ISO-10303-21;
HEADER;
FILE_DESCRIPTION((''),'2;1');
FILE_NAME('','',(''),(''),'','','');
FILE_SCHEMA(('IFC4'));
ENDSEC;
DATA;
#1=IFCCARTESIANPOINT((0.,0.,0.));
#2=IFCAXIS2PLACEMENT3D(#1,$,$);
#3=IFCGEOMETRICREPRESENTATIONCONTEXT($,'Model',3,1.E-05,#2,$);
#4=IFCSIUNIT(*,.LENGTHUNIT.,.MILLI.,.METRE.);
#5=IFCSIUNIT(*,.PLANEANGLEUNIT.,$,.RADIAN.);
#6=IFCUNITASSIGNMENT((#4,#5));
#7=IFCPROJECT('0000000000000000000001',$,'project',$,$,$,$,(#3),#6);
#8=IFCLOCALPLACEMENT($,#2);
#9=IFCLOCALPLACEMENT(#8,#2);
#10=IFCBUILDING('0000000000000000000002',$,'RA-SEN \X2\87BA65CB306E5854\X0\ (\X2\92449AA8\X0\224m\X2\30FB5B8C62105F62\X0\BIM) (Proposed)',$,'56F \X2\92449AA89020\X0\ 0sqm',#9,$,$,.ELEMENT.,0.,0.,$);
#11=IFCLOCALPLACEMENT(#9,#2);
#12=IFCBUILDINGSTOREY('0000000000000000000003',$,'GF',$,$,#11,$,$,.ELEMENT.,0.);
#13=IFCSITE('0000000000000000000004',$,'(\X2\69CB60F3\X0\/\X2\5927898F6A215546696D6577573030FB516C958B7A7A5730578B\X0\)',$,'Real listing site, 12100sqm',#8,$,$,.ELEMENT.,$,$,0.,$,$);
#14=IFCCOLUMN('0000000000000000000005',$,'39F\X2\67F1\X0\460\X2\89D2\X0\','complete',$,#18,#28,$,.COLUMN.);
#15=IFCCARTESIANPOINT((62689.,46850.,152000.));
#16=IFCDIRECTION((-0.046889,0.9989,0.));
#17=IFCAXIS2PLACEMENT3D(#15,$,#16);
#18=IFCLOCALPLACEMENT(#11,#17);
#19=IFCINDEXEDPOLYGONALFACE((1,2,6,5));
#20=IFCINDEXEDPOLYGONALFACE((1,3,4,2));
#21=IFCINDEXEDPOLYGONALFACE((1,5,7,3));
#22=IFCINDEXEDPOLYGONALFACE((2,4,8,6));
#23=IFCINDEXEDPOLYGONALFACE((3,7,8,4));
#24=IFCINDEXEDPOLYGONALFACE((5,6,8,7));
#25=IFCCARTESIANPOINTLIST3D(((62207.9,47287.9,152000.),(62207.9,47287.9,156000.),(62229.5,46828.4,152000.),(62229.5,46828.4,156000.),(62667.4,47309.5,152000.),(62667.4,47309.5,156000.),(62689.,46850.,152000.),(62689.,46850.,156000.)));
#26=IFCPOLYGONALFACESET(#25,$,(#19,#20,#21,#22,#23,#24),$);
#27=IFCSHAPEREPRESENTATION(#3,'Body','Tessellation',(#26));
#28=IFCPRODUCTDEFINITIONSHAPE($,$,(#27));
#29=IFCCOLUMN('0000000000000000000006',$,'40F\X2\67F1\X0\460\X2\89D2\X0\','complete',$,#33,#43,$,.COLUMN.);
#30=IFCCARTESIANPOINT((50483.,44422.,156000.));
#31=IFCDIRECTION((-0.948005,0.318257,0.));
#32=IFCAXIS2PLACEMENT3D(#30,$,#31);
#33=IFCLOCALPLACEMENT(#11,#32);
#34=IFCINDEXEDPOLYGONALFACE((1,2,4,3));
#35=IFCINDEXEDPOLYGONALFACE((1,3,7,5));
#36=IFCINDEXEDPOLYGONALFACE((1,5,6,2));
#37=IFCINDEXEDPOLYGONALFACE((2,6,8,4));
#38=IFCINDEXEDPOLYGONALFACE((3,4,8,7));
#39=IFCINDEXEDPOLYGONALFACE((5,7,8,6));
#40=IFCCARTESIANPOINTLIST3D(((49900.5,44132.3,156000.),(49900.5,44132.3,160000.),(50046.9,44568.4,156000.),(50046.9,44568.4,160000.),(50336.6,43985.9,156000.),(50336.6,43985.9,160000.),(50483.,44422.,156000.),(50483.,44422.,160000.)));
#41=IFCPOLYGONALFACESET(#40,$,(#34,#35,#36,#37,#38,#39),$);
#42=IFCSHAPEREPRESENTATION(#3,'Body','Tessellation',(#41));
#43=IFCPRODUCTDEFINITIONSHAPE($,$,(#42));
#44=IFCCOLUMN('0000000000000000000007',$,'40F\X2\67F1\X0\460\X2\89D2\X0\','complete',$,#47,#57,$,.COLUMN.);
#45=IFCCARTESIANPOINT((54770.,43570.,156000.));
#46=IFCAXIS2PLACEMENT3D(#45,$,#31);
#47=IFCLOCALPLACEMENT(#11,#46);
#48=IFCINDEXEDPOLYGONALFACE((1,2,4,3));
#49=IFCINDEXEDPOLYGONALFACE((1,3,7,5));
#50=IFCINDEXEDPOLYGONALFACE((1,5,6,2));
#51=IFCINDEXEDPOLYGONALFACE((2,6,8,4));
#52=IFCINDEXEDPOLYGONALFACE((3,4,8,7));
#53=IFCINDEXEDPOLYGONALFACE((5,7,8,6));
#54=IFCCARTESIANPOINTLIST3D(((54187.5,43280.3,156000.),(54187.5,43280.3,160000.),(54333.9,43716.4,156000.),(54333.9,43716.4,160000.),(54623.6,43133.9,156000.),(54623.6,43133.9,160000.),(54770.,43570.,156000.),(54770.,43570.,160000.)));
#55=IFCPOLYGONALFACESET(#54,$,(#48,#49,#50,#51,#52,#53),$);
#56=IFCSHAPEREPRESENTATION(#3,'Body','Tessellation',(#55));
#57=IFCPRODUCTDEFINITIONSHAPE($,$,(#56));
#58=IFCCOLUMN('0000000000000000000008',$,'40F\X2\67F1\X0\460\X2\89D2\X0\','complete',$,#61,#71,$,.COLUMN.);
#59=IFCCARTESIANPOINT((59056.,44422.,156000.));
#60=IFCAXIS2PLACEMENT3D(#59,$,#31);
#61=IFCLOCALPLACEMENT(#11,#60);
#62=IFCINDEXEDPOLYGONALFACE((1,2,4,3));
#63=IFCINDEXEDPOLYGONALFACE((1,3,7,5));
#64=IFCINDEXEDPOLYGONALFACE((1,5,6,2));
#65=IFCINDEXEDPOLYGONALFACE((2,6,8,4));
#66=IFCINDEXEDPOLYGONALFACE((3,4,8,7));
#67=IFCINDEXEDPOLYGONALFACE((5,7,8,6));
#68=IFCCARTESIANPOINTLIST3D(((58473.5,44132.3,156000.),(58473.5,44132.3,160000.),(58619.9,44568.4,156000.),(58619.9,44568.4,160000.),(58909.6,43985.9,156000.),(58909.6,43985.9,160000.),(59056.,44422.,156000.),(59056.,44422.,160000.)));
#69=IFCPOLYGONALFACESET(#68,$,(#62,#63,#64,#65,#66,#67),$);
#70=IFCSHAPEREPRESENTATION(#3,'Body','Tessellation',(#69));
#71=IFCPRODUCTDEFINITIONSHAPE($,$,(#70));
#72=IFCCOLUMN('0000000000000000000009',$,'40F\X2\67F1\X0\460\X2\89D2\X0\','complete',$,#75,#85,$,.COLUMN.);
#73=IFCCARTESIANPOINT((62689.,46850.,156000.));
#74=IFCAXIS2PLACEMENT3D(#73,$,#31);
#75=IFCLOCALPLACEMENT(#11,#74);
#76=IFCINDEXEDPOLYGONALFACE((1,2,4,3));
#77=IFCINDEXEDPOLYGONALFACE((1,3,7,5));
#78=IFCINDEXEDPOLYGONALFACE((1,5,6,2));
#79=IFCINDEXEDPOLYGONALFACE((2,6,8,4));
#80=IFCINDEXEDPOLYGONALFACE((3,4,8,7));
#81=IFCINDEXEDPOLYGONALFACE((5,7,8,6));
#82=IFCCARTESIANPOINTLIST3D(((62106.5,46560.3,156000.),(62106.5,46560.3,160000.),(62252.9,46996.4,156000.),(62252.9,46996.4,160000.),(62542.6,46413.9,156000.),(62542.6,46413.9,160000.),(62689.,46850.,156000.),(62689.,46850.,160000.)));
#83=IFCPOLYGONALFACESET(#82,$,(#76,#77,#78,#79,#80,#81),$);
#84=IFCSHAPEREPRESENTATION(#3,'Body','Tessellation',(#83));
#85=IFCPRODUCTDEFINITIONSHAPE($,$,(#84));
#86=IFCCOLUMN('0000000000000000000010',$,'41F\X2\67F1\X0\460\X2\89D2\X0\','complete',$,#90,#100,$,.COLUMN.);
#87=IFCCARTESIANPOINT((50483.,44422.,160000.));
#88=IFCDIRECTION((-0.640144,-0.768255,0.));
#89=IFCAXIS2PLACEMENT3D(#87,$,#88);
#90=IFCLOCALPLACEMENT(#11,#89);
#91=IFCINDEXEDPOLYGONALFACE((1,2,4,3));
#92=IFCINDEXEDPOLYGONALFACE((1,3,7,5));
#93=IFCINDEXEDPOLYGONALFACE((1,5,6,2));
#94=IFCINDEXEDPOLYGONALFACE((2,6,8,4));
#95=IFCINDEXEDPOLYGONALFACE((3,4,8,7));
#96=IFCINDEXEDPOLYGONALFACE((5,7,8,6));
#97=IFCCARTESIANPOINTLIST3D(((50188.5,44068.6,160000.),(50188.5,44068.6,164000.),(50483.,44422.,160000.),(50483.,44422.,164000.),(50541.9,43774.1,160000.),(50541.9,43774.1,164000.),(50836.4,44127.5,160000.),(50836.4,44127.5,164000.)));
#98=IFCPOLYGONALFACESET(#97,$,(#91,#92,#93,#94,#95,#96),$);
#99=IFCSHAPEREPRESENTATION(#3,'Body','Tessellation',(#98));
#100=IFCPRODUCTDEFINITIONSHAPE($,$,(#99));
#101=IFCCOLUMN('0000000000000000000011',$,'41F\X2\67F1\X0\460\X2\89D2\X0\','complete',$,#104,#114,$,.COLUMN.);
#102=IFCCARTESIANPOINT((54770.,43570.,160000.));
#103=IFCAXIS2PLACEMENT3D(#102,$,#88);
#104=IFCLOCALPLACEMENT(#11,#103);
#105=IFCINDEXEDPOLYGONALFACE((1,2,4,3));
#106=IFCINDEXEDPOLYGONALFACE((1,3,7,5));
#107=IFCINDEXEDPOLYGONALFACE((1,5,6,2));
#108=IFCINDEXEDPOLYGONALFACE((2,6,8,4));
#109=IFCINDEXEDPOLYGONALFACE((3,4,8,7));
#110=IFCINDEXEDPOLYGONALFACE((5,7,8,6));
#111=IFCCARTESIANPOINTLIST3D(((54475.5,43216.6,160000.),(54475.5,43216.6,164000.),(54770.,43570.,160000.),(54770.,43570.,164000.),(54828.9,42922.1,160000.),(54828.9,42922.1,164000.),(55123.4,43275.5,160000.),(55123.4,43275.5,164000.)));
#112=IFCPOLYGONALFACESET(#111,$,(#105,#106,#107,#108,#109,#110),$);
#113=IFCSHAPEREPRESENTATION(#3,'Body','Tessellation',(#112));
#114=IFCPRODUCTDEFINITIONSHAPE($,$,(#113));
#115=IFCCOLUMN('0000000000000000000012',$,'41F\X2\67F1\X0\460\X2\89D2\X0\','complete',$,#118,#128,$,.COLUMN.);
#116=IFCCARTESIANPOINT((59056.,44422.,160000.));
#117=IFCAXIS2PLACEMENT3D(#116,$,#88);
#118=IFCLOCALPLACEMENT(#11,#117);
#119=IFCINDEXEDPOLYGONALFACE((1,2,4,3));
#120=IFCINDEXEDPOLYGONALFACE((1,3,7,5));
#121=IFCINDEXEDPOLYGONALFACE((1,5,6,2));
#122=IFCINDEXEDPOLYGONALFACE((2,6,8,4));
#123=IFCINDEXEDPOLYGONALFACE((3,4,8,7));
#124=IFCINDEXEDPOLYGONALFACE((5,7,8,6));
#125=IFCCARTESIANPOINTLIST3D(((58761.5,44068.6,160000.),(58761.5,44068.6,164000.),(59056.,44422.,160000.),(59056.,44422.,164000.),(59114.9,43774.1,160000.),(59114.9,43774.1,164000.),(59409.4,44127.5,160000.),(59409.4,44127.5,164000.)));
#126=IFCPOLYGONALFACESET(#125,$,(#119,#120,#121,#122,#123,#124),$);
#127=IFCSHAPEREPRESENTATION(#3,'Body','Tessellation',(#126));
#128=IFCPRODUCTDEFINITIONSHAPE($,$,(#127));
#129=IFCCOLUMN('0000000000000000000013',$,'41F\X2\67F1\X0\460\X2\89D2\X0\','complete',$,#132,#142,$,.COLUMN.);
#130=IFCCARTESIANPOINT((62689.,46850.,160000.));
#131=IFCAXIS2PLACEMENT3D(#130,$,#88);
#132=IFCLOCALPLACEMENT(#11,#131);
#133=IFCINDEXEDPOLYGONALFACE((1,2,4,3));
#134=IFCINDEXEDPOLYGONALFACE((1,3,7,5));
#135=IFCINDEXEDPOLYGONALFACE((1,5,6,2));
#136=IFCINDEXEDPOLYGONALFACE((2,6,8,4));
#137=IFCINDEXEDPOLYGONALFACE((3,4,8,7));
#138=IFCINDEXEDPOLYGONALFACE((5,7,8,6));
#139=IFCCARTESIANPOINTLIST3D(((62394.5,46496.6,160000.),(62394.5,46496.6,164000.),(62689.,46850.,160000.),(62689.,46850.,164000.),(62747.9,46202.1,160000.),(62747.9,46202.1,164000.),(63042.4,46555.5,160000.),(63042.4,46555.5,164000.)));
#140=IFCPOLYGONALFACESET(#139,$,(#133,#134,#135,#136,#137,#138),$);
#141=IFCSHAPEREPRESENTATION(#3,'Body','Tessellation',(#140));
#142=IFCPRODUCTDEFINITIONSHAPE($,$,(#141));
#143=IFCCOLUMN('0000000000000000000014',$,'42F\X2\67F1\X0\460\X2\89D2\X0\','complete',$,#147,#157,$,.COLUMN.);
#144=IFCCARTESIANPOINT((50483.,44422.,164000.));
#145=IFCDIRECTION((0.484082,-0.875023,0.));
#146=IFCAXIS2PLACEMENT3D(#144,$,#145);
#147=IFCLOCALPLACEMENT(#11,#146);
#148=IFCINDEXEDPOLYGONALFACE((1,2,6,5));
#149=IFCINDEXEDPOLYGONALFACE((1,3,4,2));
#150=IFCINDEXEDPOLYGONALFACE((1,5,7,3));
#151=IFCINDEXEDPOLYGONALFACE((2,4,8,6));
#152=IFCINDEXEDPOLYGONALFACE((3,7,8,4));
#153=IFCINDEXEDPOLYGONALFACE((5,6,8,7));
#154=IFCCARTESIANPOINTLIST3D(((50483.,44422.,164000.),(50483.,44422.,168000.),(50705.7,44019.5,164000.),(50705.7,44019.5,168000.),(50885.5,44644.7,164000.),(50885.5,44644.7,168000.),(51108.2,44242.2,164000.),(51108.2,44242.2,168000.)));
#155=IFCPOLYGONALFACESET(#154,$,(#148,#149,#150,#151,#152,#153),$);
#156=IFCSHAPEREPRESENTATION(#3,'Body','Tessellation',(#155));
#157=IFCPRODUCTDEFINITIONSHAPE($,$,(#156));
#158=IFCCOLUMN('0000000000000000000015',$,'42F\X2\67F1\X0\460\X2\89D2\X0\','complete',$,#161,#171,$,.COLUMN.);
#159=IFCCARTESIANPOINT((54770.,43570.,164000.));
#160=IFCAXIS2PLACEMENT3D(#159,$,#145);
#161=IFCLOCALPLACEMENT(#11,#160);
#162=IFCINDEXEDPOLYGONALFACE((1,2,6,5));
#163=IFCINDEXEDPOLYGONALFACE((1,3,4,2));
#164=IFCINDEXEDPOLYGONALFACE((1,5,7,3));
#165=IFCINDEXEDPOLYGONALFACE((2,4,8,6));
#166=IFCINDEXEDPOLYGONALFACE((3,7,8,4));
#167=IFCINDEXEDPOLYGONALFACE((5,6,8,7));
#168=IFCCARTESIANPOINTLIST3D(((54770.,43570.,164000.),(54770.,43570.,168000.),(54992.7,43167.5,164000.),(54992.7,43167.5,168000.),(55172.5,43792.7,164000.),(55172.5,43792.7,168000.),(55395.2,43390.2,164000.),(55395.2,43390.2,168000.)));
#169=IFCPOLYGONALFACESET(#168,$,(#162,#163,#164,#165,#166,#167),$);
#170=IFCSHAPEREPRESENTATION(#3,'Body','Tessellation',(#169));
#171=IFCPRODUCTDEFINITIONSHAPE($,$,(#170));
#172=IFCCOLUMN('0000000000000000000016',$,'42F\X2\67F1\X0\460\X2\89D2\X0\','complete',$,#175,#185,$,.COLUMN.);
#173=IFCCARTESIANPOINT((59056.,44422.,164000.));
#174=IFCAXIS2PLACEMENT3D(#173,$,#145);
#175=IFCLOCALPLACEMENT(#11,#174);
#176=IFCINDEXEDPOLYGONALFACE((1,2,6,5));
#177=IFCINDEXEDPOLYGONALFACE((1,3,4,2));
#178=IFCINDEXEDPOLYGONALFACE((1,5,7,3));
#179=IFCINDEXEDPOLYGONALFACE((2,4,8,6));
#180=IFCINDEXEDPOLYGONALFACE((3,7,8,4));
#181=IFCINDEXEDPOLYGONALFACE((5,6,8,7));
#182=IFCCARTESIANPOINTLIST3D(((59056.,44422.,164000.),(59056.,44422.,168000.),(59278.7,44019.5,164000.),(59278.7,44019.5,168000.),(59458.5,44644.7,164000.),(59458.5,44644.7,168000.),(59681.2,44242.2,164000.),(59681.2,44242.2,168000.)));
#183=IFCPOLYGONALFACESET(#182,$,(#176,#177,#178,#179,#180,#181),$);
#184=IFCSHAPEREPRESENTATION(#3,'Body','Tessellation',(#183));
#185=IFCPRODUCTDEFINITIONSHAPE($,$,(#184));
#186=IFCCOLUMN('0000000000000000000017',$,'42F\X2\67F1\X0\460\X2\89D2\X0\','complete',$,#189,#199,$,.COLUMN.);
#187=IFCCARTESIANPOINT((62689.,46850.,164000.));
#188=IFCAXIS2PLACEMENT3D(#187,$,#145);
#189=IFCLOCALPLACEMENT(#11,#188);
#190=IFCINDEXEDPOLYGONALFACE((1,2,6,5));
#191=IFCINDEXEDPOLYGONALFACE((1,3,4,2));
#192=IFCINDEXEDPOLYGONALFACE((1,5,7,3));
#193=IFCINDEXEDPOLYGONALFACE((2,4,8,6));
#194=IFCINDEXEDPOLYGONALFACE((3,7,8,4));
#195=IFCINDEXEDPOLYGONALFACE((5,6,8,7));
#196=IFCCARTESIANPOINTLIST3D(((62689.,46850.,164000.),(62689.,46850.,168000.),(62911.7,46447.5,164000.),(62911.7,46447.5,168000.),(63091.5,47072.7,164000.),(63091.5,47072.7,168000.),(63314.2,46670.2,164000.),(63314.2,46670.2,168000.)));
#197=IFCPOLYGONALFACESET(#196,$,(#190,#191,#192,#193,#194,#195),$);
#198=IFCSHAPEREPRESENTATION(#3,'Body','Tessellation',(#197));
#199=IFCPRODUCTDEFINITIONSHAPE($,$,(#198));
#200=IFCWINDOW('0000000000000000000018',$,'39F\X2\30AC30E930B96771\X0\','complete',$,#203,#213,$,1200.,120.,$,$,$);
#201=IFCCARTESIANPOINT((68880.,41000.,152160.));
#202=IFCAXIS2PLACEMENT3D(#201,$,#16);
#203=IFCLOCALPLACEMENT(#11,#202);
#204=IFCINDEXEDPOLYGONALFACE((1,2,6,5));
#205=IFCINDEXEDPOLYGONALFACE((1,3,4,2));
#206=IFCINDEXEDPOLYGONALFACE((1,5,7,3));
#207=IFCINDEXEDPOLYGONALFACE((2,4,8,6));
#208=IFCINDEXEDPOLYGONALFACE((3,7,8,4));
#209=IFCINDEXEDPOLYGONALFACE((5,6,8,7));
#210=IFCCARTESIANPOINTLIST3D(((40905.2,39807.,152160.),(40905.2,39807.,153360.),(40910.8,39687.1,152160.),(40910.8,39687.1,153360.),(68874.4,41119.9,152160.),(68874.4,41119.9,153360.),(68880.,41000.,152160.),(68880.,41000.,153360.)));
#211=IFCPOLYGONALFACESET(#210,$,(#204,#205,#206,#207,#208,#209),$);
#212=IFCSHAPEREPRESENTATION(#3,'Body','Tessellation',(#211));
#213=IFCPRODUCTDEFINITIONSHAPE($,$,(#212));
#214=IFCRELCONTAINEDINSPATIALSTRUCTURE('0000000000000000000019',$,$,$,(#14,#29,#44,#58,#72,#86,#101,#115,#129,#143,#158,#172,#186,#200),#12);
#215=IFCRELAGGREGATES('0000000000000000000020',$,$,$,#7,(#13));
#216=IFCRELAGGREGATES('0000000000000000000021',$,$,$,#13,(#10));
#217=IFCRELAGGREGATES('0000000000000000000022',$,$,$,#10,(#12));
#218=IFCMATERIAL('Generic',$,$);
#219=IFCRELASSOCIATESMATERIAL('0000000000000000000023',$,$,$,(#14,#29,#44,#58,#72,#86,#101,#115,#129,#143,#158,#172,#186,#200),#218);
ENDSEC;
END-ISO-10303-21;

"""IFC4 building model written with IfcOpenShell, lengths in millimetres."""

from ifc_helpers import new_model, si_unit, frame, frame_2d, origin, place, context, project, spatial, rectangle, extrude, material, element, save


model = new_model("IFC4")

# Units and contexts
model_context = context("Model", 3, precision=1e-05, world=origin())
ifc_project = project(units=[si_unit("LENGTHUNIT", "METRE", prefix="MILLI"), si_unit("PLANEANGLEUNIT", "RADIAN")], contexts=[model_context])

# Site, building, storey
site_placement = place(None, origin())
site = spatial("IfcSite", under=ifc_project, at=site_placement, Name="(構想/大規模商業敷地・公開空地型)", ObjectType="Real listing site, 12100sqm", CompositionType="ELEMENT", RefElevation=0.0)
building_placement = place(site_placement, origin())
building = spatial("IfcBuilding", under=site, at=building_placement, Name="RA-SEN 螺旋の塔 (鉄骨224m・完成形BIM) (Proposed)", ObjectType="56F 鉄骨造 0sqm", CompositionType="ELEMENT", ElevationOfRefHeight=0.0, ElevationOfTerrain=0.0)
storey_placement = place(building_placement, origin())
storey = spatial("IfcBuildingStorey", under=building, at=storey_placement, Name="GF", CompositionType="ELEMENT", Elevation=0.0)

# Columns
ifc_material = material(Name="Generic")
column_1_placement = place(storey_placement, frame((62689.0, 46850.0, 152000.0), x_axis=(-0.046889, 0.9989, 0.0)))
element("IfcColumn", 1, at=column_1_placement, inside=storey, material=ifc_material, Name="39F柱460角", Description="complete", PredefinedType="COLUMN", context=model_context, shape_type="SweptSolid", body=[
    extrude(rectangle(XDim=460.0, YDim=460.0, at=frame_2d((230.0, 230.0))), frame((62689.0, 46850.0, 152000.0), x_axis=(-0.046889, 0.9989, 0.0)), (0.0, 0.0, 1.0), 4000.0),
])
column_2_placement = place(storey_placement, frame((50483.0, 44422.0, 156000.0), x_axis=(-0.948005, 0.318257, 0.0)))
element("IfcColumn", 2, at=column_2_placement, inside=storey, material=ifc_material, Name="40F柱460角", Description="complete", PredefinedType="COLUMN", context=model_context, shape_type="SweptSolid", body=[
    extrude(rectangle(XDim=460.0, YDim=460.0, at=frame_2d((230.0, 230.0))), frame((50483.0, 44422.0, 156000.0), x_axis=(-0.948005, 0.318257, 0.0)), (0.0, 0.0, 1.0), 4000.0),
])
column_3_placement = place(storey_placement, frame((54770.0, 43570.0, 156000.0), x_axis=(-0.948005, 0.318257, 0.0)))
element("IfcColumn", 3, at=column_3_placement, inside=storey, material=ifc_material, Name="40F柱460角", Description="complete", PredefinedType="COLUMN", context=model_context, shape_type="SweptSolid", body=[
    extrude(rectangle(XDim=460.0, YDim=460.0, at=frame_2d((230.0, 230.0))), frame((54770.0, 43570.0, 156000.0), x_axis=(-0.948005, 0.318257, 0.0)), (0.0, 0.0, 1.0), 4000.0),
])
column_4_placement = place(storey_placement, frame((59056.0, 44422.0, 156000.0), x_axis=(-0.948005, 0.318257, 0.0)))
element("IfcColumn", 4, at=column_4_placement, inside=storey, material=ifc_material, Name="40F柱460角", Description="complete", PredefinedType="COLUMN", context=model_context, shape_type="SweptSolid", body=[
    extrude(rectangle(XDim=460.0, YDim=460.0, at=frame_2d((230.0, 230.0))), frame((59056.0, 44422.0, 156000.0), x_axis=(-0.948005, 0.318257, 0.0)), (0.0, 0.0, 1.0), 4000.0),
])
column_5_placement = place(storey_placement, frame((62689.0, 46850.0, 156000.0), x_axis=(-0.948005, 0.318257, 0.0)))
element("IfcColumn", 5, at=column_5_placement, inside=storey, material=ifc_material, Name="40F柱460角", Description="complete", PredefinedType="COLUMN", context=model_context, shape_type="SweptSolid", body=[
    extrude(rectangle(XDim=460.0, YDim=460.0, at=frame_2d((230.0, 230.0))), frame((62689.0, 46850.0, 156000.0), x_axis=(-0.948005, 0.318257, 0.0)), (0.0, 0.0, 1.0), 4000.0),
])
column_6_placement = place(storey_placement, frame((50483.0, 44422.0, 160000.0), x_axis=(-0.640144, -0.768255, 0.0)))
element("IfcColumn", 6, at=column_6_placement, inside=storey, material=ifc_material, Name="41F柱460角", Description="complete", PredefinedType="COLUMN", context=model_context, shape_type="SweptSolid", body=[
    extrude(rectangle(XDim=460.0, YDim=460.0, at=frame_2d((230.0, 230.0))), frame((50483.0, 44422.0, 160000.0), x_axis=(-0.640144, -0.768255, 0.0)), (0.0, 0.0, 1.0), 4000.0),
])
column_7_placement = place(storey_placement, frame((54770.0, 43570.0, 160000.0), x_axis=(-0.640144, -0.768255, 0.0)))
element("IfcColumn", 7, at=column_7_placement, inside=storey, material=ifc_material, Name="41F柱460角", Description="complete", PredefinedType="COLUMN", context=model_context, shape_type="SweptSolid", body=[
    extrude(rectangle(XDim=460.0, YDim=460.0, at=frame_2d((230.0, 230.0))), frame((54770.0, 43570.0, 160000.0), x_axis=(-0.640144, -0.768255, 0.0)), (0.0, 0.0, 1.0), 4000.0),
])
column_8_placement = place(storey_placement, frame((59056.0, 44422.0, 160000.0), x_axis=(-0.640144, -0.768255, 0.0)))
element("IfcColumn", 8, at=column_8_placement, inside=storey, material=ifc_material, Name="41F柱460角", Description="complete", PredefinedType="COLUMN", context=model_context, shape_type="SweptSolid", body=[
    extrude(rectangle(XDim=460.0, YDim=460.0, at=frame_2d((230.0, 230.0))), frame((59056.0, 44422.0, 160000.0), x_axis=(-0.640144, -0.768255, 0.0)), (0.0, 0.0, 1.0), 4000.0),
])
column_9_placement = place(storey_placement, frame((62689.0, 46850.0, 160000.0), x_axis=(-0.640144, -0.768255, 0.0)))
element("IfcColumn", 9, at=column_9_placement, inside=storey, material=ifc_material, Name="41F柱460角", Description="complete", PredefinedType="COLUMN", context=model_context, shape_type="SweptSolid", body=[
    extrude(rectangle(XDim=460.0, YDim=460.0, at=frame_2d((230.0, 230.0))), frame((62689.0, 46850.0, 160000.0), x_axis=(-0.640144, -0.768255, 0.0)), (0.0, 0.0, 1.0), 4000.0),
])
column_10_placement = place(storey_placement, frame((50483.0, 44422.0, 164000.0), x_axis=(0.484082, -0.875023, 0.0)))
element("IfcColumn", 10, at=column_10_placement, inside=storey, material=ifc_material, Name="42F柱460角", Description="complete", PredefinedType="COLUMN", context=model_context, shape_type="SweptSolid", body=[
    extrude(rectangle(XDim=460.0, YDim=460.0, at=frame_2d((230.0, 230.0))), frame((50483.0, 44422.0, 164000.0), x_axis=(0.484082, -0.875023, 0.0)), (0.0, 0.0, 1.0), 4000.0),
])
column_11_placement = place(storey_placement, frame((54770.0, 43570.0, 164000.0), x_axis=(0.484082, -0.875023, 0.0)))
element("IfcColumn", 11, at=column_11_placement, inside=storey, material=ifc_material, Name="42F柱460角", Description="complete", PredefinedType="COLUMN", context=model_context, shape_type="SweptSolid", body=[
    extrude(rectangle(XDim=460.0, YDim=460.0, at=frame_2d((230.0, 230.0))), frame((54770.0, 43570.0, 164000.0), x_axis=(0.484082, -0.875023, 0.0)), (0.0, 0.0, 1.0), 4000.0),
])
column_12_placement = place(storey_placement, frame((59056.0, 44422.0, 164000.0), x_axis=(0.484082, -0.875023, 0.0)))
element("IfcColumn", 12, at=column_12_placement, inside=storey, material=ifc_material, Name="42F柱460角", Description="complete", PredefinedType="COLUMN", context=model_context, shape_type="SweptSolid", body=[
    extrude(rectangle(XDim=460.0, YDim=460.0, at=frame_2d((230.0, 230.0))), frame((59056.0, 44422.0, 164000.0), x_axis=(0.484082, -0.875023, 0.0)), (0.0, 0.0, 1.0), 4000.0),
])
column_13_placement = place(storey_placement, frame((62689.0, 46850.0, 164000.0), x_axis=(0.484082, -0.875023, 0.0)))
element("IfcColumn", 13, at=column_13_placement, inside=storey, material=ifc_material, Name="42F柱460角", Description="complete", PredefinedType="COLUMN", context=model_context, shape_type="SweptSolid", body=[
    extrude(rectangle(XDim=460.0, YDim=460.0, at=frame_2d((230.0, 230.0))), frame((62689.0, 46850.0, 164000.0), x_axis=(0.484082, -0.875023, 0.0)), (0.0, 0.0, 1.0), 4000.0),
])

# Window
window_1_placement = place(storey_placement, frame((68880.0, 41000.0, 152160.0), x_axis=(-0.046889, 0.9989, 0.0)))
element("IfcWindow", 14, at=window_1_placement, inside=storey, material=ifc_material, Name="39Fガラス東", Description="complete", OverallHeight=1200.0, OverallWidth=120.0, context=model_context, shape_type="SweptSolid", body=[
    extrude(rectangle(XDim=120.0, YDim=28000.0, at=frame_2d((60.0, 14000.0))), frame((68880.0, 41000.0, 152160.0), x_axis=(-0.046889, 0.9989, 0.0)), (0.0, 0.0, 1.0), 1200.0),
])

save(model, "model.ifc")
